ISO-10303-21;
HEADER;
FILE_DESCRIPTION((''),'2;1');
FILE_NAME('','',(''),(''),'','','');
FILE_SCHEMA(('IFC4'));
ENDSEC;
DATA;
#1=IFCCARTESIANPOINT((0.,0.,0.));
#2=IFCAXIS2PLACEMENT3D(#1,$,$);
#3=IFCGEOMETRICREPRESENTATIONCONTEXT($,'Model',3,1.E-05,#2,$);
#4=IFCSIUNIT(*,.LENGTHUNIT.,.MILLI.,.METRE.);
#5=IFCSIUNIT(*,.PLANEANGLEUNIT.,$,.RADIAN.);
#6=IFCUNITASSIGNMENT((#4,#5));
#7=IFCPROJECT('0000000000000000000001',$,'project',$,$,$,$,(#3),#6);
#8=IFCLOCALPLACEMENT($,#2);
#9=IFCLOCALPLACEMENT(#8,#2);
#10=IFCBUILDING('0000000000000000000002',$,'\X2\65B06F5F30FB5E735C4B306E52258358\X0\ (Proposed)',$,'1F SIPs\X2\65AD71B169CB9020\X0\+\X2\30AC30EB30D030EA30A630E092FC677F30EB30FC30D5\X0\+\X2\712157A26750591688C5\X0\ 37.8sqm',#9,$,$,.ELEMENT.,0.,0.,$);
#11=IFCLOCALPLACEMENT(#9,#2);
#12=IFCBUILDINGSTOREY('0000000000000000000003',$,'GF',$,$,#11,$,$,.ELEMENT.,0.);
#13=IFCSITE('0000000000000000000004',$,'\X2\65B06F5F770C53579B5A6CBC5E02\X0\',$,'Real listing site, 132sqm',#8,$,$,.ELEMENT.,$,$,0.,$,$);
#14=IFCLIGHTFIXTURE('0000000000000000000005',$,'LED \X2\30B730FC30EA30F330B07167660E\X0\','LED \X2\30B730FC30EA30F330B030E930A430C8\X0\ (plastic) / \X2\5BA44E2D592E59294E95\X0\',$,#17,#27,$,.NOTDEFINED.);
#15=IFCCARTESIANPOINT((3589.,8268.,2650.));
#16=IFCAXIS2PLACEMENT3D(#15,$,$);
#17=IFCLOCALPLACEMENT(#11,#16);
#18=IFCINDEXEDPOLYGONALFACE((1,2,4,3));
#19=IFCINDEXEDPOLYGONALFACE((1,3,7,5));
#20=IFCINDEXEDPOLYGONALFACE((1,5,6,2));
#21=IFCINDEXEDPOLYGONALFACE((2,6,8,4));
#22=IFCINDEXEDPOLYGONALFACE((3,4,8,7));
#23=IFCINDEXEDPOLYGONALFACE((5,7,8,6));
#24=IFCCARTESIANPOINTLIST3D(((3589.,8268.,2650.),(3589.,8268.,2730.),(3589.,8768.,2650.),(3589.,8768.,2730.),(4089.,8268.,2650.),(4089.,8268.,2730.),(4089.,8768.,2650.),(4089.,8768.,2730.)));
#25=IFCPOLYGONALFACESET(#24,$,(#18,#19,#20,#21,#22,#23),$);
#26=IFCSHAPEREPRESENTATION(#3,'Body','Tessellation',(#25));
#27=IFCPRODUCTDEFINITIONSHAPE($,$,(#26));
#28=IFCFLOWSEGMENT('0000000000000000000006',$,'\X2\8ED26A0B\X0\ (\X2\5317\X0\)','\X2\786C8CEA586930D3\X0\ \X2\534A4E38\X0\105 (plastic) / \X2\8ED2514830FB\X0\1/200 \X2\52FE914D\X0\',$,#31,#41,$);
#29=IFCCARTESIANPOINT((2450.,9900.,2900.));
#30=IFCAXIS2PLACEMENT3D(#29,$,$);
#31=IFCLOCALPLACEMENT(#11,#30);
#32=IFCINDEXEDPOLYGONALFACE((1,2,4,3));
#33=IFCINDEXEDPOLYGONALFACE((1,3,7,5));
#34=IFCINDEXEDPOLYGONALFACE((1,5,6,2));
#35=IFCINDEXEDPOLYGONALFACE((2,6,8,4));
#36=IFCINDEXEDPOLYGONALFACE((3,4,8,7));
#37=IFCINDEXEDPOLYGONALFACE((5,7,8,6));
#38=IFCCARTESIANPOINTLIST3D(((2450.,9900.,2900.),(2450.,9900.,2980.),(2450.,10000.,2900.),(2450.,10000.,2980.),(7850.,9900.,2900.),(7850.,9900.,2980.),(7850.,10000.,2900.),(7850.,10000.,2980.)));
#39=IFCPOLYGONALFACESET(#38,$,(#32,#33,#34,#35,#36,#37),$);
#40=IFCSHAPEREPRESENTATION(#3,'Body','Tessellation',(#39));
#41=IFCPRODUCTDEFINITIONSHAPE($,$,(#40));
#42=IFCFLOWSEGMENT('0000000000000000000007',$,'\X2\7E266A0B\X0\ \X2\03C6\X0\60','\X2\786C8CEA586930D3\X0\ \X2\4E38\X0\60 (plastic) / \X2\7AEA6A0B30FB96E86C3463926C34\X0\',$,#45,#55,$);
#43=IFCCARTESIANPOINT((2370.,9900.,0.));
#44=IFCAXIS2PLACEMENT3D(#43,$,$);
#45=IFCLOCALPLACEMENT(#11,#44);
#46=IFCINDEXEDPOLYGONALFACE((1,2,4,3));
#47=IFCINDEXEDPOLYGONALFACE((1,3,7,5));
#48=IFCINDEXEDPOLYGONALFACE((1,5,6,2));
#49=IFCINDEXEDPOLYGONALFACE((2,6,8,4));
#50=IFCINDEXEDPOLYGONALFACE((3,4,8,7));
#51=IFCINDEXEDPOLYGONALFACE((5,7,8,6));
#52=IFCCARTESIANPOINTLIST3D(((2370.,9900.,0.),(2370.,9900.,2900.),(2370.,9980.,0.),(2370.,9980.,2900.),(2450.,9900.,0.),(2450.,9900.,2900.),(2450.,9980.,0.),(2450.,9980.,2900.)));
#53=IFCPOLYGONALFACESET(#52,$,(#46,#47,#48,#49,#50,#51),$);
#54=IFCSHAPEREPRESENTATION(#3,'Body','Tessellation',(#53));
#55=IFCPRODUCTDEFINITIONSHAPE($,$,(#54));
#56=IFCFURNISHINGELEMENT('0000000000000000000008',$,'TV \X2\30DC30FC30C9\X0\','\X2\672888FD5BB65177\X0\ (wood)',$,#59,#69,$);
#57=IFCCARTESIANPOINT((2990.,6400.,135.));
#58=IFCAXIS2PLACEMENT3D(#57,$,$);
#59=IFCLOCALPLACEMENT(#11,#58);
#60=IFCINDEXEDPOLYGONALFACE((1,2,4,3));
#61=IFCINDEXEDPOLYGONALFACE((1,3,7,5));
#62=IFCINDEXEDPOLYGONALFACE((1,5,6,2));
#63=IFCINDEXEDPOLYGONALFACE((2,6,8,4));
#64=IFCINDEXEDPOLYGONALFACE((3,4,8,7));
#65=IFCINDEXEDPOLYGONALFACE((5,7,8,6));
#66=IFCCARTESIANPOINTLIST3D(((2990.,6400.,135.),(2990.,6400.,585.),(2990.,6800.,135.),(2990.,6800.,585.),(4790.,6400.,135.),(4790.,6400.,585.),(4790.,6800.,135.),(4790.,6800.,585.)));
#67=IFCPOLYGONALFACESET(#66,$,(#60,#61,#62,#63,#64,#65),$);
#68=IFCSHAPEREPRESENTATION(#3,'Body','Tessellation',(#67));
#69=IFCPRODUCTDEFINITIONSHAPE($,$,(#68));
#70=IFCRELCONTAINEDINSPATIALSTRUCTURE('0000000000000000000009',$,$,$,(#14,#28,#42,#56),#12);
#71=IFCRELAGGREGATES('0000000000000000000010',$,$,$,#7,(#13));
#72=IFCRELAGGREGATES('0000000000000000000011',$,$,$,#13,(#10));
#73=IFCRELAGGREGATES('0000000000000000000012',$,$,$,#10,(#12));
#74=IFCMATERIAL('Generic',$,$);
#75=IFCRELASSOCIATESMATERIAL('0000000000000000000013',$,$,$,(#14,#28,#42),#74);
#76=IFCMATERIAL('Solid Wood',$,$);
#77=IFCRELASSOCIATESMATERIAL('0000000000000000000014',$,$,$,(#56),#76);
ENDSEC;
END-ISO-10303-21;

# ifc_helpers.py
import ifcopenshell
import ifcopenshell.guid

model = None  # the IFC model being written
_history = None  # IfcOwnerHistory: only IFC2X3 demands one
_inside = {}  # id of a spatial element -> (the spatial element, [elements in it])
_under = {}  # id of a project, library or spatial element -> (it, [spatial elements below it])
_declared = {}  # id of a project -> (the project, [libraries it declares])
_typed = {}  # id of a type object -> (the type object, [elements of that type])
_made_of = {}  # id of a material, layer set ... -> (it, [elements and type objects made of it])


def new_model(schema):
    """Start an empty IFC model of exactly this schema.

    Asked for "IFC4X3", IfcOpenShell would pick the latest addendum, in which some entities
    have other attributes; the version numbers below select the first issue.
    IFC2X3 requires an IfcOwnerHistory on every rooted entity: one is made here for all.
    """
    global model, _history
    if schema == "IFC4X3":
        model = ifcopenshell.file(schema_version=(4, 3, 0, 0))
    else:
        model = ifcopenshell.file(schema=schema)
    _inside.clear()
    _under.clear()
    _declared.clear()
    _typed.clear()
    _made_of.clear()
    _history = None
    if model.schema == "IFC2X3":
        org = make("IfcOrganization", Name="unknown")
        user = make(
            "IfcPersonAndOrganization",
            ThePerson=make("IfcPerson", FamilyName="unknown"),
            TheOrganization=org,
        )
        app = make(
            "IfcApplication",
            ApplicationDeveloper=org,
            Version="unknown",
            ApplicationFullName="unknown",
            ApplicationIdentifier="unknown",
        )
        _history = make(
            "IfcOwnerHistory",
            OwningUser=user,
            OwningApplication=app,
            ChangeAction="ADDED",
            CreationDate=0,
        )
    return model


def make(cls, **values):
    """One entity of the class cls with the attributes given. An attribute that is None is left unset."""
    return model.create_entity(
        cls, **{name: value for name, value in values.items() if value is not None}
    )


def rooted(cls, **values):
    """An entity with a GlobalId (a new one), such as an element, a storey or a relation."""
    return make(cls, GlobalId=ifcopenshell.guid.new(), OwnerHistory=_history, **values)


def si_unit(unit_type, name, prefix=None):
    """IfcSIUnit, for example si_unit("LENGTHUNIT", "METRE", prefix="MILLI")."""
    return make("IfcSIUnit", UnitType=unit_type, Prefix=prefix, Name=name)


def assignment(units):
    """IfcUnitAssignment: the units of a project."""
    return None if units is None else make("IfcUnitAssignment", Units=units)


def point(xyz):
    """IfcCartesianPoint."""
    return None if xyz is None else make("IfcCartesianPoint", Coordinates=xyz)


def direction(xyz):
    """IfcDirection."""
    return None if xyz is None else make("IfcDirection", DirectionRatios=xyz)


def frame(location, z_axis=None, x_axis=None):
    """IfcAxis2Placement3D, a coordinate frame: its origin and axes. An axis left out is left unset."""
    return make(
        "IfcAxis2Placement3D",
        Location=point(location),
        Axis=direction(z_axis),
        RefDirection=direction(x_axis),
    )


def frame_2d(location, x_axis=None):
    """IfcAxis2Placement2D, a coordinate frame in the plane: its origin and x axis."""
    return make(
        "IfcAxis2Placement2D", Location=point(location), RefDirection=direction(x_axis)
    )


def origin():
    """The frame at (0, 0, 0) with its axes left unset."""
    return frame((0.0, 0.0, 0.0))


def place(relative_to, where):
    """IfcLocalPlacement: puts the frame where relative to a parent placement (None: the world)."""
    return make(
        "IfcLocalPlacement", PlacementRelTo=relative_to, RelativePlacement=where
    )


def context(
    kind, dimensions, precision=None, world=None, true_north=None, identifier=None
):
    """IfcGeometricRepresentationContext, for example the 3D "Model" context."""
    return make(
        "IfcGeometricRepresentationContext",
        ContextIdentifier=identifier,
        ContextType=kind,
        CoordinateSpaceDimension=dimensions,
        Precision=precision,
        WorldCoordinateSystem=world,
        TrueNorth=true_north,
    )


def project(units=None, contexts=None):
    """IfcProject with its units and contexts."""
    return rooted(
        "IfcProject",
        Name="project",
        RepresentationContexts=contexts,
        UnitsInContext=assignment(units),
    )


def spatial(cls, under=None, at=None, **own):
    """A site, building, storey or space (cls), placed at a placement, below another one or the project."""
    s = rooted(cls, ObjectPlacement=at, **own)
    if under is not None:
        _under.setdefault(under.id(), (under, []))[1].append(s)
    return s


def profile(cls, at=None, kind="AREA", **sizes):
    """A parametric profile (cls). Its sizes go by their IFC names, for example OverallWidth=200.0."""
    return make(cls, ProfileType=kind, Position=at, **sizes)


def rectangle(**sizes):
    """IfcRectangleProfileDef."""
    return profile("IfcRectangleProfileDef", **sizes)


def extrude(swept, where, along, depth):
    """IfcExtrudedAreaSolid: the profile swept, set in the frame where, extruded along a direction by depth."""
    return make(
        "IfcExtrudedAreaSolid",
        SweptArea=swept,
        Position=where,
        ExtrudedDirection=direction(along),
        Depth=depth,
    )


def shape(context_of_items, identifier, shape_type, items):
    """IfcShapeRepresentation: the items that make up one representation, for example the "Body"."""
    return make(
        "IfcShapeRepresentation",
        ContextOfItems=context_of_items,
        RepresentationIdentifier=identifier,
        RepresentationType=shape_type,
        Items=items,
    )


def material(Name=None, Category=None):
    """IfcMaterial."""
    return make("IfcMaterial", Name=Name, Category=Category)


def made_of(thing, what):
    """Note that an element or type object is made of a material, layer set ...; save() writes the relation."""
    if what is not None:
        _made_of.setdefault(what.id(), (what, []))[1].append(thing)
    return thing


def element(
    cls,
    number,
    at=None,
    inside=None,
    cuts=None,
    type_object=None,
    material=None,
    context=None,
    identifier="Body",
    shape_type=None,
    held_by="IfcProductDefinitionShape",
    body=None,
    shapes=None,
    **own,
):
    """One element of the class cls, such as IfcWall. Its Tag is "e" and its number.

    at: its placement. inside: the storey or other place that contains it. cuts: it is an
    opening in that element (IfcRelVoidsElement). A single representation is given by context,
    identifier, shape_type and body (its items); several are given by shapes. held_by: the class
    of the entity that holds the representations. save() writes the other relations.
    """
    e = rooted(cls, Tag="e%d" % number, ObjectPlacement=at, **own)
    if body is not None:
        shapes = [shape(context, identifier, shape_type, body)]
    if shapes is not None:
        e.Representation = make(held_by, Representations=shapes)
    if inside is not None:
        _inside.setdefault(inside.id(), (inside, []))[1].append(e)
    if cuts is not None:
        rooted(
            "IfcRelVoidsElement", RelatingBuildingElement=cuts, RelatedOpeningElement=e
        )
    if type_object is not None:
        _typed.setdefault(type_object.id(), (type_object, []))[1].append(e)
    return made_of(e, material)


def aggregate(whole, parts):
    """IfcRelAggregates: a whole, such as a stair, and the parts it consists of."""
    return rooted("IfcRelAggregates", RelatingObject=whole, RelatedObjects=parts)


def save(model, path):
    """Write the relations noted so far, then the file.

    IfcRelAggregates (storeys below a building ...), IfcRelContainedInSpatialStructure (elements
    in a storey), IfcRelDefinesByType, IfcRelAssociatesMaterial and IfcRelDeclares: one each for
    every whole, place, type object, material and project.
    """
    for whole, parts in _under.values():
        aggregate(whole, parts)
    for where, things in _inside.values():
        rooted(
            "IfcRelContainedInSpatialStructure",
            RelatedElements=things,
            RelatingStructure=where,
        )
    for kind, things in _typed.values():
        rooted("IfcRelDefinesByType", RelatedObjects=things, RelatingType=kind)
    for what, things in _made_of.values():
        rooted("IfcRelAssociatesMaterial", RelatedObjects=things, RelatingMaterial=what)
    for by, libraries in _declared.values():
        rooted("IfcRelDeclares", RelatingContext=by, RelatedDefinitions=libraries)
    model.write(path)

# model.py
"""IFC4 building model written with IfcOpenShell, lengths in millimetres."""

from ifc_helpers import new_model, si_unit, frame, frame_2d, origin, place, context, project, spatial, rectangle, extrude, material, element, save


model = new_model("IFC4")

# Units and contexts
model_context = context("Model", 3, precision=1e-05, world=origin())
ifc_project = project(units=[si_unit("LENGTHUNIT", "METRE", prefix="MILLI"), si_unit("PLANEANGLEUNIT", "RADIAN")], contexts=[model_context])

# Site, building, storey
site_placement = place(None, origin())
site = spatial("IfcSite", under=ifc_project, at=site_placement, Name="新潟県南魚沼市", ObjectType="Real listing site, 132sqm", CompositionType="ELEMENT", RefElevation=0.0)
building_placement = place(site_placement, origin())
building = spatial("IfcBuilding", under=site, at=building_placement, Name="新潟・平屋の別荘 (Proposed)", ObjectType="1F SIPs断熱構造+ガルバリウム鋼板ルーフ+無垢材外装 37.8sqm", CompositionType="ELEMENT", ElevationOfRefHeight=0.0, ElevationOfTerrain=0.0)
storey_placement = place(building_placement, origin())
storey = spatial("IfcBuildingStorey", under=building, at=storey_placement, Name="GF", CompositionType="ELEMENT", Elevation=0.0)

# Shared definitions
ifc_material_1 = material(Name="Solid Wood")

# Shared definitions
ifc_material_2 = material(Name="Generic")

# Light fixture
light_fixture_placement = place(storey_placement, frame((3589.0, 8268.0, 2650.0)))
element("IfcLightFixture", 1, at=light_fixture_placement, inside=storey, material=ifc_material_2, Name="LED シーリング照明", Description="LED シーリングライト (plastic) / 室中央天井", PredefinedType="NOTDEFINED", context=model_context, shape_type="SweptSolid", body=[
    extrude(rectangle(XDim=500.0, YDim=500.0, at=frame_2d((250.0, 250.0))), frame((3589.0, 8268.0, 2650.0)), (0.0, 0.0, 1.0), 80.0),
])

# Flow segments
flow_segment_1_placement = place(storey_placement, frame((2450.0, 9900.0, 2900.0)))
element("IfcFlowSegment", 2, at=flow_segment_1_placement, inside=storey, material=ifc_material_2, Name="軒樋 (北)", Description="硬質塩ビ 半丸105 (plastic) / 軒先・1/200 勾配", context=model_context, shape_type="SweptSolid", body=[
    extrude(rectangle(XDim=5400.0, YDim=100.0, at=frame_2d((2700.0, 50.0))), frame((2450.0, 9900.0, 2900.0)), (0.0, 0.0, 1.0), 80.0),
])
flow_segment_2_placement = place(storey_placement, frame((2370.0, 9900.0, 0.0)))
element("IfcFlowSegment", 3, at=flow_segment_2_placement, inside=storey, material=ifc_material_2, Name="縦樋 φ60", Description="硬質塩ビ 丸60 (plastic) / 竪樋・雨水排水", context=model_context, shape_type="SweptSolid", body=[
    extrude(rectangle(XDim=80.0, YDim=80.0, at=frame_2d((40.0, 40.0))), frame((2370.0, 9900.0, 0.0)), (0.0, 0.0, 1.0), 2900.0),
])

# Furnishing element
furnishing_placement = place(storey_placement, frame((2990.0, 6400.0, 135.0)))
element("IfcFurnishingElement", 4, at=furnishing_placement, inside=storey, material=ifc_material_1, Name="TV ボード", Description="木製家具 (wood)", context=model_context, shape_type="SweptSolid", body=[
    extrude(rectangle(XDim=1800.0, YDim=400.0, at=frame_2d((900.0, 200.0))), frame((2990.0, 6400.0, 135.0)), (0.0, 0.0, 1.0), 450.0),
])

save(model, "model.ifc")
